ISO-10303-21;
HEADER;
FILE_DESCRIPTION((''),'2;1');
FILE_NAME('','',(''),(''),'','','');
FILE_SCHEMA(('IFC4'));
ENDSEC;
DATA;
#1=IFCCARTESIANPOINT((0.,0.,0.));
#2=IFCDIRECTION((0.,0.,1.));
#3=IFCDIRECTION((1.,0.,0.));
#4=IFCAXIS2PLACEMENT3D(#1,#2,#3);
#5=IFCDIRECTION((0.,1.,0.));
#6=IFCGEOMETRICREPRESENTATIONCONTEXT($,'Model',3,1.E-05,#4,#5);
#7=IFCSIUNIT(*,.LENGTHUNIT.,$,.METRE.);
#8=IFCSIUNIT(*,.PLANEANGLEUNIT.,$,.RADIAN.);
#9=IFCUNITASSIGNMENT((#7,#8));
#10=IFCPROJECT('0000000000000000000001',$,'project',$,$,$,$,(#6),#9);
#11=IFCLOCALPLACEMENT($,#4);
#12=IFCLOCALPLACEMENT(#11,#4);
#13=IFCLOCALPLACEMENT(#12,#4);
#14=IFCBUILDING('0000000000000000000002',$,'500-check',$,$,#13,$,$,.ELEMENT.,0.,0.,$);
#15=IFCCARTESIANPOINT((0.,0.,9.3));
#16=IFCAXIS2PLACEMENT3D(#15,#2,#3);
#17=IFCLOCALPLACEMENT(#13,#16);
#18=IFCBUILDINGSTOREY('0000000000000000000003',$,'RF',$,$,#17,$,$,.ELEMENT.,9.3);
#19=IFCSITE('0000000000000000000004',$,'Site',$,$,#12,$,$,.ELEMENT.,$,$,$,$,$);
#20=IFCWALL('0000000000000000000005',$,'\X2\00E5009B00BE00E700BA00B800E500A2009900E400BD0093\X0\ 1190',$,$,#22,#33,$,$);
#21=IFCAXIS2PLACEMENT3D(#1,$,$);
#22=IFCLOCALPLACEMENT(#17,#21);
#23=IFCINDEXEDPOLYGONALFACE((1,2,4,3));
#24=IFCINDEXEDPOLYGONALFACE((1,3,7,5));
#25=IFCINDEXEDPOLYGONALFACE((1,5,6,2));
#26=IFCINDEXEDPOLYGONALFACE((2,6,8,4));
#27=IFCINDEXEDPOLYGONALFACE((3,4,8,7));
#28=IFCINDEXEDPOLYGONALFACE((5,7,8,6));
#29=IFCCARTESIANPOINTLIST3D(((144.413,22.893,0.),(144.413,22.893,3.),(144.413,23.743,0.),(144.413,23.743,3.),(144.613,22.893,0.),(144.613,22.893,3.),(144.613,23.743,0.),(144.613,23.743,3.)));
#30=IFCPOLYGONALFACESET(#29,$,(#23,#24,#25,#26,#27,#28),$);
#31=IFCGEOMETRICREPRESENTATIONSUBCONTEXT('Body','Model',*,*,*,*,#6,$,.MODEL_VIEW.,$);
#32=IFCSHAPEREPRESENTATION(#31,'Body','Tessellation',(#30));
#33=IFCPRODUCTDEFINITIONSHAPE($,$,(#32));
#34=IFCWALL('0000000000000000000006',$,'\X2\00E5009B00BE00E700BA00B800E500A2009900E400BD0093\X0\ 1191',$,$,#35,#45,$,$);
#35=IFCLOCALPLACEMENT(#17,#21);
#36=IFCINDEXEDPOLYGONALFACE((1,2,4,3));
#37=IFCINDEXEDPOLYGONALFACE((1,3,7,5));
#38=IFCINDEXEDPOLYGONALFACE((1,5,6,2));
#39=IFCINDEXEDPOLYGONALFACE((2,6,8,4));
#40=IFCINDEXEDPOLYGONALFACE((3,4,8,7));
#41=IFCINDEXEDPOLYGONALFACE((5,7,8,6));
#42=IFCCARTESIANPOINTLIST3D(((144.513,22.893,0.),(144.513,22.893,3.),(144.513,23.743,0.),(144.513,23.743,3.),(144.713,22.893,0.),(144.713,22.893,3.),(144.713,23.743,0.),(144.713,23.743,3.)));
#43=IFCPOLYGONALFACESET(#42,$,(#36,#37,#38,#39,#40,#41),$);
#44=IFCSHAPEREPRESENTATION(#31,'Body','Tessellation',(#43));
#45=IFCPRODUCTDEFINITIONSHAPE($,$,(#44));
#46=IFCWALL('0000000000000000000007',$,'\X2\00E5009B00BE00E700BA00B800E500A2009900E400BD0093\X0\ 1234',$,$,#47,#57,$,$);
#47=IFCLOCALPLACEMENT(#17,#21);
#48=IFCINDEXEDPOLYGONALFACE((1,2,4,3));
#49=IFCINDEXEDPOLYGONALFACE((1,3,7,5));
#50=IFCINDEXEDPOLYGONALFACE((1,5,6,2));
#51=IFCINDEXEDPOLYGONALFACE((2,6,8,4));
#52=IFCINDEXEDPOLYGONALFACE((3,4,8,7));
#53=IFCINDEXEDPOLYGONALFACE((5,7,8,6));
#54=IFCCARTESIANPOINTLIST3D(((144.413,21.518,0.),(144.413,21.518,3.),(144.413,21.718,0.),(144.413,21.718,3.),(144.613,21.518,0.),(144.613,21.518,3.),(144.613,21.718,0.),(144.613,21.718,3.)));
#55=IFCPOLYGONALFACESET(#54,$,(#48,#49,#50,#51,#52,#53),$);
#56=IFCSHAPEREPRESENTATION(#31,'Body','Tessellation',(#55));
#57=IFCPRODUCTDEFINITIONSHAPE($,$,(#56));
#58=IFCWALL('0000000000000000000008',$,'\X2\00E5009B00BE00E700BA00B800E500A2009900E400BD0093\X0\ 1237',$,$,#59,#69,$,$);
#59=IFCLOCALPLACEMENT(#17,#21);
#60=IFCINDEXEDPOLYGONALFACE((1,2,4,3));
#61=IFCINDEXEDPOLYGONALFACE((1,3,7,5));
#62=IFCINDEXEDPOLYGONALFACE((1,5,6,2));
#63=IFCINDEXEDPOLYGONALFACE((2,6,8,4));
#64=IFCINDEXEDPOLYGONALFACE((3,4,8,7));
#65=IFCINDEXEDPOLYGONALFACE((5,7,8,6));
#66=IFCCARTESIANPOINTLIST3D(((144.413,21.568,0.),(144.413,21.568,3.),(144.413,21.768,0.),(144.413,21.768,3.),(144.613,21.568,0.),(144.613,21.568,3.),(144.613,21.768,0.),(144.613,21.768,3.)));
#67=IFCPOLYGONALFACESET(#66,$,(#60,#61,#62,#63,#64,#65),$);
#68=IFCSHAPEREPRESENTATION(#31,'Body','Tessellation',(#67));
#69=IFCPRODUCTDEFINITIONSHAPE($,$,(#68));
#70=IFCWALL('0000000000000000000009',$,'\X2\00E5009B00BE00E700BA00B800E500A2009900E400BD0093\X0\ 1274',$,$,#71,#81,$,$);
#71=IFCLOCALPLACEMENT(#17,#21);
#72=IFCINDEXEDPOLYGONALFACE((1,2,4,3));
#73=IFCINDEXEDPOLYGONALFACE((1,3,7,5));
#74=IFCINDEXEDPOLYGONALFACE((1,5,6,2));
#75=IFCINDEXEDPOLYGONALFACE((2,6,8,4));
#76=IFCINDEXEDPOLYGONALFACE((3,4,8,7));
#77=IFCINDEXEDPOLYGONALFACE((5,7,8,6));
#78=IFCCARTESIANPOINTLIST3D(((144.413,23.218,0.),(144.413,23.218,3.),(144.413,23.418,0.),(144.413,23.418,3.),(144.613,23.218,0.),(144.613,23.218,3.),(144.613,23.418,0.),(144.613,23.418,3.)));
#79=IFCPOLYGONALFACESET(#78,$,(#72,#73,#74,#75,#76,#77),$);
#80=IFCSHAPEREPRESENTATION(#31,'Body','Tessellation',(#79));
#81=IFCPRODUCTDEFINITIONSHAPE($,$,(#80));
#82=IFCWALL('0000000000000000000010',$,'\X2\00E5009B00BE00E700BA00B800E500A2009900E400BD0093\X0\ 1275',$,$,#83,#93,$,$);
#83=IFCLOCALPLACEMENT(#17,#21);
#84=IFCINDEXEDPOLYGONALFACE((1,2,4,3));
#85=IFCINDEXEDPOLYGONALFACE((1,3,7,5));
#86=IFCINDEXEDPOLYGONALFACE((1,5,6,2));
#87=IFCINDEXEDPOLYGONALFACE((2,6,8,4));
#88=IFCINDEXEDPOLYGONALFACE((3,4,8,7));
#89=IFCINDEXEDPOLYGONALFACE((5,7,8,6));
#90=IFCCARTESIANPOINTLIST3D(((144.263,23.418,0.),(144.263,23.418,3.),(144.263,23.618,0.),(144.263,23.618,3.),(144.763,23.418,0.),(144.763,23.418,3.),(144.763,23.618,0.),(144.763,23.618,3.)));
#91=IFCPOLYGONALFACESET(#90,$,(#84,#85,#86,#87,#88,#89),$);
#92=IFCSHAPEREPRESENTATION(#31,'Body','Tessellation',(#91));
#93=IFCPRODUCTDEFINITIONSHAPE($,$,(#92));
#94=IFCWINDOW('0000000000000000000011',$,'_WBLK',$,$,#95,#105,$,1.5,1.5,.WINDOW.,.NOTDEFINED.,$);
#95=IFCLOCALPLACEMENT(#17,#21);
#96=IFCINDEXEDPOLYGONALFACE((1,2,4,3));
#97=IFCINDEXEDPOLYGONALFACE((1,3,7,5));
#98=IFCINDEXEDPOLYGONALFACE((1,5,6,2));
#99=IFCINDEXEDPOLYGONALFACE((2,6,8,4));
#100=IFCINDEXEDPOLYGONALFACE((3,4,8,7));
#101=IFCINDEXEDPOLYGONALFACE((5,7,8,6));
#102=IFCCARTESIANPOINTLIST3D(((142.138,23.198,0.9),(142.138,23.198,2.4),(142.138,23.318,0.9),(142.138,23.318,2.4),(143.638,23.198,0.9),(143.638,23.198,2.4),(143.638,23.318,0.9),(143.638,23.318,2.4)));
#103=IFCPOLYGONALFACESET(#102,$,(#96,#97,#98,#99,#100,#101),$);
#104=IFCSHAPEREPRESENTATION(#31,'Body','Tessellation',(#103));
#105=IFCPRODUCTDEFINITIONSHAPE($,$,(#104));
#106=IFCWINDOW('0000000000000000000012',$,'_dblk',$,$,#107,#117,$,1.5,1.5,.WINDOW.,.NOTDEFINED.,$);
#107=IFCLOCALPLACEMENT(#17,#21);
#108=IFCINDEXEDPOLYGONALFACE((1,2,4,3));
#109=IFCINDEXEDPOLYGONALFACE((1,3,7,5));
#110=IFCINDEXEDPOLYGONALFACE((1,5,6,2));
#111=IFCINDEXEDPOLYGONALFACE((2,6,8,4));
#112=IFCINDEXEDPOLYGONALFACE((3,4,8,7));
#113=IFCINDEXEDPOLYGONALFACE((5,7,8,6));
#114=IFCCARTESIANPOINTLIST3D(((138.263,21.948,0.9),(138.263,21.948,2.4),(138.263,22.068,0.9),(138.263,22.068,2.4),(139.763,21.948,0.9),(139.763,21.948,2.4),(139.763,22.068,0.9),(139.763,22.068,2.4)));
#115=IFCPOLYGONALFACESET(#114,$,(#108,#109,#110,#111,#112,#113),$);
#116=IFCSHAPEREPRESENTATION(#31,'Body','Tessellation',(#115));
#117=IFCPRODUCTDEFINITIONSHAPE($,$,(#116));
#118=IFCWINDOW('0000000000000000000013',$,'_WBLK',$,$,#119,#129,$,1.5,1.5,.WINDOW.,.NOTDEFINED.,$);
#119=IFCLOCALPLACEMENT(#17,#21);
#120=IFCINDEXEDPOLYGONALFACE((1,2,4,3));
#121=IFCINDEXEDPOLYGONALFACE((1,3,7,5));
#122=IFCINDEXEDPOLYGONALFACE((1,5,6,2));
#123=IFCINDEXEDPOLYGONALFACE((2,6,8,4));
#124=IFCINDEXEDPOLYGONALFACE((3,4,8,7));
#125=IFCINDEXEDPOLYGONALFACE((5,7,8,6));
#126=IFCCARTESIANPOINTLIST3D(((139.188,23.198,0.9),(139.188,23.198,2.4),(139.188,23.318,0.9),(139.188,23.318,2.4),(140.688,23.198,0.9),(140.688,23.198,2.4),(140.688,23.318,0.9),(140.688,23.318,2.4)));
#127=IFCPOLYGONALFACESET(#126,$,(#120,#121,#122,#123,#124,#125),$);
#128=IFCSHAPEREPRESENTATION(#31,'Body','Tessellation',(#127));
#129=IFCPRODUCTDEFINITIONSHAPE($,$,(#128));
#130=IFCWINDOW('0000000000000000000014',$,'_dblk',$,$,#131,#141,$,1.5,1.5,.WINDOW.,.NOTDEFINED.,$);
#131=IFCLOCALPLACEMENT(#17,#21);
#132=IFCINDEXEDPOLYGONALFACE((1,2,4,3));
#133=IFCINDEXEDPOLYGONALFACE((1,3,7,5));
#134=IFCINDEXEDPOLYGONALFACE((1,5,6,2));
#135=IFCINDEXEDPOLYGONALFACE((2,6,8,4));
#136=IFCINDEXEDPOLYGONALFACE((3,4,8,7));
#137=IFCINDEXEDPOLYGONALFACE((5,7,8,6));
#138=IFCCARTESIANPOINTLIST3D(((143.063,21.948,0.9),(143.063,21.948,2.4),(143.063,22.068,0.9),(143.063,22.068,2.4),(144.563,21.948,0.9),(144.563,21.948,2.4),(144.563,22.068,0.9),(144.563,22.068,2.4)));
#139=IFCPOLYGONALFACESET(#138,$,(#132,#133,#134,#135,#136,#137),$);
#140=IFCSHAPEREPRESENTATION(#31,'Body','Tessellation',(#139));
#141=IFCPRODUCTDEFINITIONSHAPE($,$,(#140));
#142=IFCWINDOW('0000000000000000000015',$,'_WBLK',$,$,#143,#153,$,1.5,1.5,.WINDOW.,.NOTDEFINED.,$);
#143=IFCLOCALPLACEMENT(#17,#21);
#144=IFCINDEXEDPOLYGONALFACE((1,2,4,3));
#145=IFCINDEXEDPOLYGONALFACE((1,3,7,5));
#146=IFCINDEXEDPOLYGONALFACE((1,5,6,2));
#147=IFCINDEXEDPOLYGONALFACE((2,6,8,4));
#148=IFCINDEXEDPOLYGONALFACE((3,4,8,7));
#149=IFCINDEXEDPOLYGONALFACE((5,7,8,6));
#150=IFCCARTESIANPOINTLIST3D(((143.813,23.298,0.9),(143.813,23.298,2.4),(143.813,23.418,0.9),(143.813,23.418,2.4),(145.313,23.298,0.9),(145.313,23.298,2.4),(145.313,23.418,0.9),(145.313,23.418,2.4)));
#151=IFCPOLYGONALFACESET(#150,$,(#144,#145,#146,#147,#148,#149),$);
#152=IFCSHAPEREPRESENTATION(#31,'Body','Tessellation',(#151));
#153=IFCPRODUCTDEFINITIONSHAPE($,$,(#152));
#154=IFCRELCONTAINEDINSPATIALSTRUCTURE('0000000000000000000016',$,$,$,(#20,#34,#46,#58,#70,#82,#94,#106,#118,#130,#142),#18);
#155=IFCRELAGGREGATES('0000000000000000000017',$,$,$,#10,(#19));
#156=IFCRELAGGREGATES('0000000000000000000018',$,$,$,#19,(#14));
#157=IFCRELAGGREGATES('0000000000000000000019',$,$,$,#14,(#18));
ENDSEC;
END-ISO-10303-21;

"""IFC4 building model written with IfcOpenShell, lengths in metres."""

from ifc_helpers import new_model, si_unit, direction, frame, frame_2d, origin_with_axes, place, context, subcontext, project, spatial, rectangle, extrude, element, save


model = new_model("IFC4")

# Units and contexts
model_context = context("Model", 3, precision=1e-05, world=origin_with_axes(), true_north=direction((0.0, 1.0, 0.0)))
body_context = subcontext(model_context, "Body", "Model", "MODEL_VIEW")
ifc_project = project(units=[si_unit("LENGTHUNIT", "METRE"), si_unit("PLANEANGLEUNIT", "RADIAN")], contexts=[model_context])

# Site, building, storey
placement = place(None, origin_with_axes())
site_placement = place(placement, origin_with_axes())
site = spatial("IfcSite", under=ifc_project, at=site_placement, Name="Site", CompositionType="ELEMENT")
building_placement = place(site_placement, origin_with_axes())
building = spatial("IfcBuilding", under=site, at=building_placement, Name="500-check", CompositionType="ELEMENT", ElevationOfRefHeight=0.0, ElevationOfTerrain=0.0)
storey_placement = place(building_placement, frame((0.0, 0.0, 9.3), z_axis=(0.0, 0.0, 1.0), x_axis=(1.0, 0.0, 0.0)))
storey = spatial("IfcBuildingStorey", under=building, at=storey_placement, Name="RF", CompositionType="ELEMENT", Elevation=9.3)

# Walls
for number, where, z_axis, x_axis, name in (
    (1, (144.513, 23.318, 0.0), (0.0, 0.0, 1.0), (0.0, -1.0, 0.0), "å\u009b¾çº¸å¢\u0099ä½\u0093 1190"),
    (2, (144.613, 23.318, 0.0), (0.0, 0.0, 1.0), (0.0, -1.0, 0.0), "å\u009b¾çº¸å¢\u0099ä½\u0093 1191"),
):
    element("IfcWall", number, at=place(storey_placement, frame(where, z_axis=z_axis, x_axis=x_axis)), inside=storey, Name=name, context=body_context, shape_type="SweptSolid", body=[
        extrude(rectangle(XDim=0.85, YDim=0.2, at=frame_2d((0.0, 0.0), x_axis=(1.0, 0.0, 0.0))), frame((0.0, 0.0, 0.0), z_axis=(0.0, 0.0, 1.0)), (0.0, 0.0, 1.0), 3.0),
    ])
for number, where, z_axis, x_axis, name in (
    (3, (144.513, 21.618, 0.0), (0.0, 0.0, 1.0), (0.0, -1.0, 0.0), "å\u009b¾çº¸å¢\u0099ä½\u0093 1234"),
    (4, (144.513, 21.668, 0.0), (0.0, 0.0, 1.0), (0.0, -1.0, 0.0), "å\u009b¾çº¸å¢\u0099ä½\u0093 1237"),
    (5, (144.513, 23.318, 0.0), (0.0, 0.0, 1.0), (0.0, 1.0, 0.0), "å\u009b¾çº¸å¢\u0099ä½\u0093 1274"),
):
    element("IfcWall", number, at=place(storey_placement, frame(where, z_axis=z_axis, x_axis=x_axis)), inside=storey, Name=name, context=body_context, shape_type="SweptSolid", body=[
        extrude(rectangle(XDim=0.2, YDim=0.2, at=frame_2d((0.0, 0.0), x_axis=(1.0, 0.0, 0.0))), frame((0.0, 0.0, 0.0), z_axis=(0.0, 0.0, 1.0)), (0.0, 0.0, 1.0), 3.0),
    ])
wall_1_placement = place(storey_placement, frame((144.513, 23.518, 0.0), z_axis=(0.0, 0.0, 1.0), x_axis=(1.0, 0.0, 0.0)))
element("IfcWall", 6, at=wall_1_placement, inside=storey, Name="å\u009b¾çº¸å¢\u0099ä½\u0093 1275", context=body_context, shape_type="SweptSolid", body=[
    extrude(rectangle(XDim=0.5, YDim=0.2, at=frame_2d((0.0, 0.0), x_axis=(1.0, 0.0, 0.0))), frame((0.0, 0.0, 0.0), z_axis=(0.0, 0.0, 1.0)), (0.0, 0.0, 1.0), 3.0),
])

# Windows
for number, where, z_axis, x_axis, name in (
    (7, (142.888, 23.258, 0.9), (0.0, 0.0, 1.0), (1.0, 0.0, 0.0), "_WBLK"),
    (8, (139.013, 22.008, 0.9), (0.0, 0.0, 1.0), (1.0, 0.0, 0.0), "_dblk"),
    (9, (139.938, 23.258, 0.9), (0.0, 0.0, 1.0), (1.0, 0.0, 0.0), "_WBLK"),
    (10, (143.813, 22.008, 0.9), (0.0, 0.0, 1.0), (1.0, 0.0, 0.0), "_dblk"),
    (11, (144.563, 23.358, 0.9), (0.0, 0.0, 1.0), (1.0, 0.0, 0.0), "_WBLK"),
):
    element("IfcWindow", number, at=place(storey_placement, frame(where, z_axis=z_axis, x_axis=x_axis)), inside=storey, Name=name, OverallHeight=1.5, OverallWidth=1.5, PartitioningType="NOTDEFINED", PredefinedType="WINDOW", context=body_context, shape_type="SweptSolid", body=[
        extrude(rectangle(XDim=1.5, YDim=0.12, at=frame_2d((0.0, 0.0), x_axis=(1.0, 0.0, 0.0))), frame((0.0, 0.0, 0.0), z_axis=(0.0, 0.0, 1.0)), (0.0, 0.0, 1.0), 1.5),
    ])

save(model, "model.ifc")
